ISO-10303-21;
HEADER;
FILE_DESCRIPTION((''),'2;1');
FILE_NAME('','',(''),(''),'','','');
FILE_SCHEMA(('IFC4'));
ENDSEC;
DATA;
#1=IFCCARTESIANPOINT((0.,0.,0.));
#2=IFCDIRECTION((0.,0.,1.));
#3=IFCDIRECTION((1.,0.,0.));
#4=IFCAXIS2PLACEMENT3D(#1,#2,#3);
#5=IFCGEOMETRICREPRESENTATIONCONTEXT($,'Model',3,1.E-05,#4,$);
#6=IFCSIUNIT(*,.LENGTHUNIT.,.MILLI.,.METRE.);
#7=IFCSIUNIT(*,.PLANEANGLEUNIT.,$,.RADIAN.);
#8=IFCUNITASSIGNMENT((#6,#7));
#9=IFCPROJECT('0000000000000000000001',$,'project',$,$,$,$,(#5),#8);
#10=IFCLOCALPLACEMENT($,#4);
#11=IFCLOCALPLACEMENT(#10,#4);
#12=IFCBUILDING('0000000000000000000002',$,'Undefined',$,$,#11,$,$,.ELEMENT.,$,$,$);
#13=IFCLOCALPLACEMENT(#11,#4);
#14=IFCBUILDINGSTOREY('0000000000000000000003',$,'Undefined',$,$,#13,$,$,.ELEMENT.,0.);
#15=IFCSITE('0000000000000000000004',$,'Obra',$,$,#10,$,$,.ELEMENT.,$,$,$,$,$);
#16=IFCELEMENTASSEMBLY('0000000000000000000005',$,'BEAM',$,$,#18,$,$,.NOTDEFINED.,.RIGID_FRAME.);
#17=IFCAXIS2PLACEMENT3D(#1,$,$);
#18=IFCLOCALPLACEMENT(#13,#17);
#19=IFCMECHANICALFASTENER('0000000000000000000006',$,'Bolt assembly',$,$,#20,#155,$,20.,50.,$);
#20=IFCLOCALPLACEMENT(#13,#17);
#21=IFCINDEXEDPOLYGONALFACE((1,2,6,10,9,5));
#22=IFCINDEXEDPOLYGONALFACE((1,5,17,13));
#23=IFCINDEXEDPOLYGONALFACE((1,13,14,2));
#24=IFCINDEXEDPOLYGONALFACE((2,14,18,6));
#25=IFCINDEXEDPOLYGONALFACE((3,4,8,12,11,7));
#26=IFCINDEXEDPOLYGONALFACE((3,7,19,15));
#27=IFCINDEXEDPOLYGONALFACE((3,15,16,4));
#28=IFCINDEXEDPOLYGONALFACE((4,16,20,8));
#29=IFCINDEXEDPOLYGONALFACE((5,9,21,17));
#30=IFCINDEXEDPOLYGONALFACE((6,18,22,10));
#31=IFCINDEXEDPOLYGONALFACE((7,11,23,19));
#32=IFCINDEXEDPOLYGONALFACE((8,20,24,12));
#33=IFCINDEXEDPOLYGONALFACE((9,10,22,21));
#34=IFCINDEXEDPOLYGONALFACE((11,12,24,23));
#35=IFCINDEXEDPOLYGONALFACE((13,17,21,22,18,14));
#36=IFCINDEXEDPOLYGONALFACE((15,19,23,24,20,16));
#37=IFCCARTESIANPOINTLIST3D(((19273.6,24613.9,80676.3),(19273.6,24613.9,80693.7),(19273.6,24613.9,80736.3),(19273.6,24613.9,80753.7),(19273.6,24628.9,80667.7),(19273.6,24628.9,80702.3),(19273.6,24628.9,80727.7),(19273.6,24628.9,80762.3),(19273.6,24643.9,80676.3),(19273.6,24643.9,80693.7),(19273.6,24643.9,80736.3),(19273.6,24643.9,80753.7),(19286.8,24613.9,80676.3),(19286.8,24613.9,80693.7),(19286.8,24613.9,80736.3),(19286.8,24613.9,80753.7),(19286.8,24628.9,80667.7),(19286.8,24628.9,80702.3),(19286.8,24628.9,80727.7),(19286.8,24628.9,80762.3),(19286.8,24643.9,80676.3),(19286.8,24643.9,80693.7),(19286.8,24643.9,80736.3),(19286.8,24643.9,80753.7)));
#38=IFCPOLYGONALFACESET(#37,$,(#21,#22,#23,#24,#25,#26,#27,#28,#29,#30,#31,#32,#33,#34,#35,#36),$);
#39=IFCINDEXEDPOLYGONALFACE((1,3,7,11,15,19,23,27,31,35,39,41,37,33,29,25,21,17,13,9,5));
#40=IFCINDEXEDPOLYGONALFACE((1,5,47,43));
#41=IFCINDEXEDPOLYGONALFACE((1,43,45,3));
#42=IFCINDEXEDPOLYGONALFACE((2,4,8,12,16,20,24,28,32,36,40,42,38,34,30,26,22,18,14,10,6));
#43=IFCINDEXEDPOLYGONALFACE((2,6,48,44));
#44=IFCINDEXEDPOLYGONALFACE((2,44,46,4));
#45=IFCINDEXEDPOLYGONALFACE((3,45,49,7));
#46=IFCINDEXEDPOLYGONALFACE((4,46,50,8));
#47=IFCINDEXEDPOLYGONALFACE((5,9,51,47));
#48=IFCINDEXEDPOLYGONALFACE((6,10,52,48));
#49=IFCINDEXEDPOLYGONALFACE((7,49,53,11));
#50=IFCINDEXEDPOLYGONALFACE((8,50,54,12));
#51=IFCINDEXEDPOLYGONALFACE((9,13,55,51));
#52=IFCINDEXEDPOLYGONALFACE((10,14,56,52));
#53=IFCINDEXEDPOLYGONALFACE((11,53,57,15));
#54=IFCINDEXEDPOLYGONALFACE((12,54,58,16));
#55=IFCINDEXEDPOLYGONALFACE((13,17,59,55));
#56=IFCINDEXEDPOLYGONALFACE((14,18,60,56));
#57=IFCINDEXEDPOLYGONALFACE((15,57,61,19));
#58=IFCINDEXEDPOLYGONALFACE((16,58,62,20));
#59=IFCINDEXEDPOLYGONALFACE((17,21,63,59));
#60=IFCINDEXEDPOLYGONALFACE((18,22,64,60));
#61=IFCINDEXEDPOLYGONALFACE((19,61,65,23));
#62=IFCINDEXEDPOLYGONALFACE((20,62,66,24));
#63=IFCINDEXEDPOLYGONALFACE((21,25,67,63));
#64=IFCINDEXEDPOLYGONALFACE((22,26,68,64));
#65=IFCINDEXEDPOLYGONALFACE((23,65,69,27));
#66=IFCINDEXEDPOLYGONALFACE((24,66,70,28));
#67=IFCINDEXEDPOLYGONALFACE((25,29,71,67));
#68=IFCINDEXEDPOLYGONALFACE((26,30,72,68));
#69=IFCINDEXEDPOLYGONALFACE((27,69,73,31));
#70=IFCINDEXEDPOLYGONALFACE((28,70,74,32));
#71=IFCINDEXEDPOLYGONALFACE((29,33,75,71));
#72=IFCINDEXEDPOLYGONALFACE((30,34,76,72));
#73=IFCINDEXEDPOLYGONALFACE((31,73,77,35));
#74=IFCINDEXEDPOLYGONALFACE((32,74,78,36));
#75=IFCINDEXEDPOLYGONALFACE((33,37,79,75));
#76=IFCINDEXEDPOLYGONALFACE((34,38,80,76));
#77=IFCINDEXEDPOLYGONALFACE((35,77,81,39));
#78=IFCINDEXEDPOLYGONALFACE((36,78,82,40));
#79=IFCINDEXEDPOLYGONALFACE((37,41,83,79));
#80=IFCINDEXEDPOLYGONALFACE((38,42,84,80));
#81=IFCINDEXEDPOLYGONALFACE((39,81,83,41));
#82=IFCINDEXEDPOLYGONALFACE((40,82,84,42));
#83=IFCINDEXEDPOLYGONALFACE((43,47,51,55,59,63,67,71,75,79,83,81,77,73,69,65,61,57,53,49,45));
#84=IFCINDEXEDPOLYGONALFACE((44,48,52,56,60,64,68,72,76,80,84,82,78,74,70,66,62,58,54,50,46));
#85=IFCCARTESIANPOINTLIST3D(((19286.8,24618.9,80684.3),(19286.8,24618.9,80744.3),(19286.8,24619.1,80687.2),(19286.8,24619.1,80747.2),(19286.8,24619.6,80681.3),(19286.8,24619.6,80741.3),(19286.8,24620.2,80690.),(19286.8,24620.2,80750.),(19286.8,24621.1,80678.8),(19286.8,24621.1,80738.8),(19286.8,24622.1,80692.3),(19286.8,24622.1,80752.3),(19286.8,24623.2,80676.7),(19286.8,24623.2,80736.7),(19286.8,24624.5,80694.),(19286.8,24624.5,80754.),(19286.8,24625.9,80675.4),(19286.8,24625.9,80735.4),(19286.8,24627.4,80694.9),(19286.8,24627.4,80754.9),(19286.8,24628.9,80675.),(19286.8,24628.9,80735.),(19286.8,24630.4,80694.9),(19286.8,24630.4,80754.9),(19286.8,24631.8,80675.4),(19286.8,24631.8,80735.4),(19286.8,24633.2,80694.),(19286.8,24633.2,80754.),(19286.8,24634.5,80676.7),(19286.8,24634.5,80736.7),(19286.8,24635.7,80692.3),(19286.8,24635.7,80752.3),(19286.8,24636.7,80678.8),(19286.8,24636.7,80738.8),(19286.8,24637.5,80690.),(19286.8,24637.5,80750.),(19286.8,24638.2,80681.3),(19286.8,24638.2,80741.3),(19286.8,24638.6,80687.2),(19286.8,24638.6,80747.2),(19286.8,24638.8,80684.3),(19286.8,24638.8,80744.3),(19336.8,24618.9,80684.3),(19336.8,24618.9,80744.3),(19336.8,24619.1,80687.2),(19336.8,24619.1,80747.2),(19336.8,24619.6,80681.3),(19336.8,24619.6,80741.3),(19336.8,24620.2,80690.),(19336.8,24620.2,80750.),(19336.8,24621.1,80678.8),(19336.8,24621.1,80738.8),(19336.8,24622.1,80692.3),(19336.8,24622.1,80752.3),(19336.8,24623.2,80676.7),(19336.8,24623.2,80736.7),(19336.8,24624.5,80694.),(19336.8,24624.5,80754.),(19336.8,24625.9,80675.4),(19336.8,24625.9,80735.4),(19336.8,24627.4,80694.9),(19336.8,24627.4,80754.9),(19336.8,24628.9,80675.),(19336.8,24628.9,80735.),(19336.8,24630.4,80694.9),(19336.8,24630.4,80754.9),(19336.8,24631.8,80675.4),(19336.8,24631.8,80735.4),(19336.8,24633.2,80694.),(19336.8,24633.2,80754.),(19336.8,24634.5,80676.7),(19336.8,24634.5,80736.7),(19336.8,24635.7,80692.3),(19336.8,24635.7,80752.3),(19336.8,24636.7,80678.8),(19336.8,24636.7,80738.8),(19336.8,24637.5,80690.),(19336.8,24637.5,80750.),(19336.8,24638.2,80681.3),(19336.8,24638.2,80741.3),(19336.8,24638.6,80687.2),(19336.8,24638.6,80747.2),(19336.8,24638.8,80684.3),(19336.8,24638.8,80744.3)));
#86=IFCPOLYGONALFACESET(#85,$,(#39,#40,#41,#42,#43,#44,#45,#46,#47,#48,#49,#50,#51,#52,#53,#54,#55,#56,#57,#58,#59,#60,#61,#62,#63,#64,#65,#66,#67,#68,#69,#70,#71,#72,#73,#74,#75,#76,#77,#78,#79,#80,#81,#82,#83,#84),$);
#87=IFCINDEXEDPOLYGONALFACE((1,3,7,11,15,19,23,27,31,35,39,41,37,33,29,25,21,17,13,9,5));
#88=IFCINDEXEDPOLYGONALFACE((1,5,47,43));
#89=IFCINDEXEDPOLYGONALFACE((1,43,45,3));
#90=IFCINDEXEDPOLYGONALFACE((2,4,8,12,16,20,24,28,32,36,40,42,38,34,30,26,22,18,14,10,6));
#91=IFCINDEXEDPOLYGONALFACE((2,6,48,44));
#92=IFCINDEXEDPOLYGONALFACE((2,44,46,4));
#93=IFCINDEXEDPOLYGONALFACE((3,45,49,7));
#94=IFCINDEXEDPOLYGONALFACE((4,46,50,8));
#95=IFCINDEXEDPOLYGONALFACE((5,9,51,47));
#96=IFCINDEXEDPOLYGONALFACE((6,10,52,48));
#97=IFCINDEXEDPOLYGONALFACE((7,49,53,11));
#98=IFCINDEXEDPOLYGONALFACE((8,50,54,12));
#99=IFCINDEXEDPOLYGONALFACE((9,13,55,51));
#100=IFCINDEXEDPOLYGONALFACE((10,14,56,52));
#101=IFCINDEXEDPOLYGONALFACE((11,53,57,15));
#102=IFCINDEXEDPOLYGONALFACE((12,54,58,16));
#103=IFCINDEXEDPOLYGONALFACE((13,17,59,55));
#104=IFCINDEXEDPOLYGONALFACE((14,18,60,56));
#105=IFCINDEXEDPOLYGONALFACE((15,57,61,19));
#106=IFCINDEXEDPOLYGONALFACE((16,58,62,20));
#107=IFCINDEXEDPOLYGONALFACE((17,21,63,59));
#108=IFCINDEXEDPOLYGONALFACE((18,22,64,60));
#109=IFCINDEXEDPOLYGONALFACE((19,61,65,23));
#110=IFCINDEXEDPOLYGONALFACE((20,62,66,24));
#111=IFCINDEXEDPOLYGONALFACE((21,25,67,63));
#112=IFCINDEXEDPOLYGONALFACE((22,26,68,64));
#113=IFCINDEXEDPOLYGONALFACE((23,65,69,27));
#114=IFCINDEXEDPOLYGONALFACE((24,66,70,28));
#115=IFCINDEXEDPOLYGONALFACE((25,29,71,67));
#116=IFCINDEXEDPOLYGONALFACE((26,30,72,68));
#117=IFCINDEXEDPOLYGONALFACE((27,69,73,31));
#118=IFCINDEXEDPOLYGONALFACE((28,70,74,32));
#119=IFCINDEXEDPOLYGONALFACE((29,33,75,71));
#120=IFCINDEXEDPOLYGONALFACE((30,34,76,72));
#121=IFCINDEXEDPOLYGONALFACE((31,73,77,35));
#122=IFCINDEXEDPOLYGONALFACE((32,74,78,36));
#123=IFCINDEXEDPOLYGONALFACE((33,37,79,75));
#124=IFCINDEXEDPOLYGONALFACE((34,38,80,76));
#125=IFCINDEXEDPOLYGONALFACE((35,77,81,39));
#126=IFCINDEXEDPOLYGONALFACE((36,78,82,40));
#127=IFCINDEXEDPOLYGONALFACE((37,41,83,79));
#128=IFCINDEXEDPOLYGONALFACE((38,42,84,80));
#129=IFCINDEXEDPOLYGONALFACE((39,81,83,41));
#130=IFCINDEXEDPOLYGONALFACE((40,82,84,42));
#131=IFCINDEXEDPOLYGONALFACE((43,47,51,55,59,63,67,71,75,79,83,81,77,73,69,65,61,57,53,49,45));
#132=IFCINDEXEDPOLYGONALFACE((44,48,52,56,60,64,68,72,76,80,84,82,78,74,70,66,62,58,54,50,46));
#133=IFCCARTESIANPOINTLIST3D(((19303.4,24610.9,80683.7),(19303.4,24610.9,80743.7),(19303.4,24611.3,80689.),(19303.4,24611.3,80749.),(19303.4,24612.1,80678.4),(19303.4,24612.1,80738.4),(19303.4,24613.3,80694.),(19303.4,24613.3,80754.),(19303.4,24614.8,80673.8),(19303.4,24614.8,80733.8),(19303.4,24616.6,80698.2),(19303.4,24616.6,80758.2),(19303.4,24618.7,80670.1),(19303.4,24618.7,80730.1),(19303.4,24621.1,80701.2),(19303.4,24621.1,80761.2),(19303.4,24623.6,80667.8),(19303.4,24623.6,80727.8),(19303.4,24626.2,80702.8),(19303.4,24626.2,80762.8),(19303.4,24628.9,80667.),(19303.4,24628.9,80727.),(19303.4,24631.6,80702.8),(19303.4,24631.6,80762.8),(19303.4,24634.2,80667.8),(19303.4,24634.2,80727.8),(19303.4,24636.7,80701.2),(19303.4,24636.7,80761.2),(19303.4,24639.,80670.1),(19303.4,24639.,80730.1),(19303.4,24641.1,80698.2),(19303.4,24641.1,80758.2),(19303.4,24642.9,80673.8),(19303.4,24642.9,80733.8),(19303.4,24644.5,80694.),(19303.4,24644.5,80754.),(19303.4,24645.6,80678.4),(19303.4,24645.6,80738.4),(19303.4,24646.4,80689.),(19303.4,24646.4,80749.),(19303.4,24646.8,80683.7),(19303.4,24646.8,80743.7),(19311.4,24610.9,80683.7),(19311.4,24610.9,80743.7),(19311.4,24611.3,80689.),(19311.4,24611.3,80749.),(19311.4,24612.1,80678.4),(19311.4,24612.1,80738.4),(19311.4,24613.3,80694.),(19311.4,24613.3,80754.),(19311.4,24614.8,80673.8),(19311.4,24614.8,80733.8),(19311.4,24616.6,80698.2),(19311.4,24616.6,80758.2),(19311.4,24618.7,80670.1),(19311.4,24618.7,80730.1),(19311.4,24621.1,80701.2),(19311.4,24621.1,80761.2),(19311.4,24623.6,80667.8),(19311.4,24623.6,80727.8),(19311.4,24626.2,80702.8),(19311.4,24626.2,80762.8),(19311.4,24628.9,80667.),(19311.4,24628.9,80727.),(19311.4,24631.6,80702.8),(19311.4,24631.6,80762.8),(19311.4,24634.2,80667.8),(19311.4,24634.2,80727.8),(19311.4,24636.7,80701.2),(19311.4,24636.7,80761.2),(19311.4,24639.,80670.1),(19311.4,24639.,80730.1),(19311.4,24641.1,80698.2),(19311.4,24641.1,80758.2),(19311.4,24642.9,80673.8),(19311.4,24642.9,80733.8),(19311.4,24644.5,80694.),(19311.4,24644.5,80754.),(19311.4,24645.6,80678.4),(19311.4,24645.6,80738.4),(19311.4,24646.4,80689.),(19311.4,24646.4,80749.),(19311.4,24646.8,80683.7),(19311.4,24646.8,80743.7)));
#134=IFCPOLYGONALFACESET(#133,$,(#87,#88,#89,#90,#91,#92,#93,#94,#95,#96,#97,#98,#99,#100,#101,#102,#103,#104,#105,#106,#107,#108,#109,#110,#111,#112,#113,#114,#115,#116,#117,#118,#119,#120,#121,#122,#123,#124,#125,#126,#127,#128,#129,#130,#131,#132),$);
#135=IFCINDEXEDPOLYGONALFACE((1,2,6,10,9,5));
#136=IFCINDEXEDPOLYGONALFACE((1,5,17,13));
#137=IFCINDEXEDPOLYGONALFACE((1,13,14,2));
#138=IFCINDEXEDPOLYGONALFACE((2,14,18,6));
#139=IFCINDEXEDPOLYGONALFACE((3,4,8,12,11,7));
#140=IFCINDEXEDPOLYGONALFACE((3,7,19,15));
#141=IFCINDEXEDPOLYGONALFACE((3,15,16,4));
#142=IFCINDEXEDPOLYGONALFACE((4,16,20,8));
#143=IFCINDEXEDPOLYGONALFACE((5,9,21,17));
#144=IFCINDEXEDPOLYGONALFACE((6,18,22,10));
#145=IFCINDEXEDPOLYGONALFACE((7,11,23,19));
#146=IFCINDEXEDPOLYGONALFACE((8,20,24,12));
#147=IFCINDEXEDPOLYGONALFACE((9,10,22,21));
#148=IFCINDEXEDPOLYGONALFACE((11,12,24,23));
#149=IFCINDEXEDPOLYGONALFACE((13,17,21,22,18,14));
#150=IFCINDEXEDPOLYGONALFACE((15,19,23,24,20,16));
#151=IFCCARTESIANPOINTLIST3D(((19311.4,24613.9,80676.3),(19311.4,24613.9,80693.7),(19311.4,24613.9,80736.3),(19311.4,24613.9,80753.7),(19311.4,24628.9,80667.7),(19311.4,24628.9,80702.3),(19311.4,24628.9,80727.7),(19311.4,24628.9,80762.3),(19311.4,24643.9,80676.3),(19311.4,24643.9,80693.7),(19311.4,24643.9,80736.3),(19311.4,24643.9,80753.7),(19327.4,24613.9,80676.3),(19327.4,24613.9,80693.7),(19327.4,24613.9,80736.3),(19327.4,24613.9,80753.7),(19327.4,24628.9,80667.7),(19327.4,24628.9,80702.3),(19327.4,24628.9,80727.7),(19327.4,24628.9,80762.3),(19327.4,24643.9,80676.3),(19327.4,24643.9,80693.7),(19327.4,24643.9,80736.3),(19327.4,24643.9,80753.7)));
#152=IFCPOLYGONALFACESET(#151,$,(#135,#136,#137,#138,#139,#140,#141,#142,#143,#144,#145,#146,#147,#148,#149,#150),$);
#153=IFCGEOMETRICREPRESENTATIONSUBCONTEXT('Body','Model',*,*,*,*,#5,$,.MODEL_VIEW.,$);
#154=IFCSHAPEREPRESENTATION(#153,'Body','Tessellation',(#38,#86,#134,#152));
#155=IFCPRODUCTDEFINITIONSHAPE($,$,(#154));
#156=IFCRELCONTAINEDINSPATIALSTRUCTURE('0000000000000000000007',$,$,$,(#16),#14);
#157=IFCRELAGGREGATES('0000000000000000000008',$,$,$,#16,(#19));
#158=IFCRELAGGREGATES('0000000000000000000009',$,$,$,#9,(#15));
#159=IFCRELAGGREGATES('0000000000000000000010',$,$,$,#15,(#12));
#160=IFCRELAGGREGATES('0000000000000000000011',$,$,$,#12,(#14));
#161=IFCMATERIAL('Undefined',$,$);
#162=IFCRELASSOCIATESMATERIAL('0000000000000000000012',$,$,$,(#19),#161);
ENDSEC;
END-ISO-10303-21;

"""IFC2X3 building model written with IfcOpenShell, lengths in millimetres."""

from ifc_helpers import new_model, si_unit, frame, origin_with_axes, origin_2d_with_axis, place, context, subcontext, project, spatial, polyline, circle, outline, extrude, source, transform, mapped, material, element, aggregate, save


model = new_model("IFC2X3")

# Units and contexts
model_context = context("Model", 3, precision=1e-05, world=origin_with_axes())
body_context = subcontext(model_context, "Body", "Model", "MODEL_VIEW")
ifc_project = project(units=[si_unit("LENGTHUNIT", "METRE", prefix="MILLI"), si_unit("PLANEANGLEUNIT", "RADIAN")], contexts=[model_context])

# Site, building, storey
site_placement = place(None, origin_with_axes())
site = spatial("IfcSite", under=ifc_project, at=site_placement, Name="Obra", CompositionType="ELEMENT")
building_placement = place(site_placement, origin_with_axes())
building = spatial("IfcBuilding", under=site, at=building_placement, Name="Undefined", CompositionType="ELEMENT")
storey_placement = place(building_placement, origin_with_axes())
storey = spatial("IfcBuildingStorey", under=building, at=storey_placement, Name="Undefined", CompositionType="ELEMENT", Elevation=0.0)

# Element assembly, mechanical fastener
assembly_1_placement = place(storey_placement, origin_with_axes())
assembly_1 = element("IfcElementAssembly", 1, at=assembly_1_placement, inside=storey, Name="BEAM", AssemblyPlace="NOTDEFINED", PredefinedType="RIGID_FRAME")
ifc_material_1 = material(Name="Undefined")
shared_shape_1 = source(origin_with_axes(), body_context, "Body", "SweptSolid", [
    extrude(outline(polyline([(17.3, 0.0), (8.7, 15.0), (-8.7, 15.0), (-17.3, 0.0), (-8.7, -15.0), (8.7, -15.0), (17.3, 0.0)])), frame((0.0, -26.5, 0.0), z_axis=(0.0, 1.0, 0.0), x_axis=(1.0, 0.0, 0.0)), (0.0, 0.0, 1.0), 13.2),
    extrude(circle(Radius=10.0, at=origin_2d_with_axis()), frame((0.0, -13.3, 0.0), z_axis=(0.0, 1.0, 0.0), x_axis=(1.0, 0.0, 0.0)), (0.0, 0.0, 1.0), 50.0),
    extrude(circle(Radius=18.0, at=origin_2d_with_axis()), frame((0.0, 3.3, 0.0), z_axis=(0.0, 1.0, 0.0), x_axis=(1.0, 0.0, 0.0)), (0.0, 0.0, 1.0), 8.0),
    extrude(outline(polyline([(17.3, 0.0), (8.7, 15.0), (-8.7, 15.0), (-17.3, 0.0), (-8.7, -15.0), (8.7, -15.0), (17.3, 0.0)])), frame((0.0, 11.3, 0.0), z_axis=(0.0, 1.0, 0.0), x_axis=(1.0, 0.0, 0.0)), (0.0, 0.0, 1.0), 16.0),
])
mechanical_fastener_1_placement = place(assembly_1_placement, frame((19300.1, 24668.9, 80850.0), z_axis=(0.000001, -1.0, 0.0), x_axis=(0.0, 0.0, -1.0)))
mechanical_fastener_1 = element("IfcMechanicalFastener", 2, at=mechanical_fastener_1_placement, material=ifc_material_1, Name="Bolt assembly", NominalDiameter=20.0, NominalLength=50.0, context=body_context, shape_type="MappedRepresentation", body=[
    mapped(shared_shape_1, transform((105.0, 0.0, 40.0))),
    mapped(shared_shape_1, transform((165.0, 0.0, 40.0))),
])

aggregate(assembly_1, [mechanical_fastener_1])

save(model, "model.ifc")
